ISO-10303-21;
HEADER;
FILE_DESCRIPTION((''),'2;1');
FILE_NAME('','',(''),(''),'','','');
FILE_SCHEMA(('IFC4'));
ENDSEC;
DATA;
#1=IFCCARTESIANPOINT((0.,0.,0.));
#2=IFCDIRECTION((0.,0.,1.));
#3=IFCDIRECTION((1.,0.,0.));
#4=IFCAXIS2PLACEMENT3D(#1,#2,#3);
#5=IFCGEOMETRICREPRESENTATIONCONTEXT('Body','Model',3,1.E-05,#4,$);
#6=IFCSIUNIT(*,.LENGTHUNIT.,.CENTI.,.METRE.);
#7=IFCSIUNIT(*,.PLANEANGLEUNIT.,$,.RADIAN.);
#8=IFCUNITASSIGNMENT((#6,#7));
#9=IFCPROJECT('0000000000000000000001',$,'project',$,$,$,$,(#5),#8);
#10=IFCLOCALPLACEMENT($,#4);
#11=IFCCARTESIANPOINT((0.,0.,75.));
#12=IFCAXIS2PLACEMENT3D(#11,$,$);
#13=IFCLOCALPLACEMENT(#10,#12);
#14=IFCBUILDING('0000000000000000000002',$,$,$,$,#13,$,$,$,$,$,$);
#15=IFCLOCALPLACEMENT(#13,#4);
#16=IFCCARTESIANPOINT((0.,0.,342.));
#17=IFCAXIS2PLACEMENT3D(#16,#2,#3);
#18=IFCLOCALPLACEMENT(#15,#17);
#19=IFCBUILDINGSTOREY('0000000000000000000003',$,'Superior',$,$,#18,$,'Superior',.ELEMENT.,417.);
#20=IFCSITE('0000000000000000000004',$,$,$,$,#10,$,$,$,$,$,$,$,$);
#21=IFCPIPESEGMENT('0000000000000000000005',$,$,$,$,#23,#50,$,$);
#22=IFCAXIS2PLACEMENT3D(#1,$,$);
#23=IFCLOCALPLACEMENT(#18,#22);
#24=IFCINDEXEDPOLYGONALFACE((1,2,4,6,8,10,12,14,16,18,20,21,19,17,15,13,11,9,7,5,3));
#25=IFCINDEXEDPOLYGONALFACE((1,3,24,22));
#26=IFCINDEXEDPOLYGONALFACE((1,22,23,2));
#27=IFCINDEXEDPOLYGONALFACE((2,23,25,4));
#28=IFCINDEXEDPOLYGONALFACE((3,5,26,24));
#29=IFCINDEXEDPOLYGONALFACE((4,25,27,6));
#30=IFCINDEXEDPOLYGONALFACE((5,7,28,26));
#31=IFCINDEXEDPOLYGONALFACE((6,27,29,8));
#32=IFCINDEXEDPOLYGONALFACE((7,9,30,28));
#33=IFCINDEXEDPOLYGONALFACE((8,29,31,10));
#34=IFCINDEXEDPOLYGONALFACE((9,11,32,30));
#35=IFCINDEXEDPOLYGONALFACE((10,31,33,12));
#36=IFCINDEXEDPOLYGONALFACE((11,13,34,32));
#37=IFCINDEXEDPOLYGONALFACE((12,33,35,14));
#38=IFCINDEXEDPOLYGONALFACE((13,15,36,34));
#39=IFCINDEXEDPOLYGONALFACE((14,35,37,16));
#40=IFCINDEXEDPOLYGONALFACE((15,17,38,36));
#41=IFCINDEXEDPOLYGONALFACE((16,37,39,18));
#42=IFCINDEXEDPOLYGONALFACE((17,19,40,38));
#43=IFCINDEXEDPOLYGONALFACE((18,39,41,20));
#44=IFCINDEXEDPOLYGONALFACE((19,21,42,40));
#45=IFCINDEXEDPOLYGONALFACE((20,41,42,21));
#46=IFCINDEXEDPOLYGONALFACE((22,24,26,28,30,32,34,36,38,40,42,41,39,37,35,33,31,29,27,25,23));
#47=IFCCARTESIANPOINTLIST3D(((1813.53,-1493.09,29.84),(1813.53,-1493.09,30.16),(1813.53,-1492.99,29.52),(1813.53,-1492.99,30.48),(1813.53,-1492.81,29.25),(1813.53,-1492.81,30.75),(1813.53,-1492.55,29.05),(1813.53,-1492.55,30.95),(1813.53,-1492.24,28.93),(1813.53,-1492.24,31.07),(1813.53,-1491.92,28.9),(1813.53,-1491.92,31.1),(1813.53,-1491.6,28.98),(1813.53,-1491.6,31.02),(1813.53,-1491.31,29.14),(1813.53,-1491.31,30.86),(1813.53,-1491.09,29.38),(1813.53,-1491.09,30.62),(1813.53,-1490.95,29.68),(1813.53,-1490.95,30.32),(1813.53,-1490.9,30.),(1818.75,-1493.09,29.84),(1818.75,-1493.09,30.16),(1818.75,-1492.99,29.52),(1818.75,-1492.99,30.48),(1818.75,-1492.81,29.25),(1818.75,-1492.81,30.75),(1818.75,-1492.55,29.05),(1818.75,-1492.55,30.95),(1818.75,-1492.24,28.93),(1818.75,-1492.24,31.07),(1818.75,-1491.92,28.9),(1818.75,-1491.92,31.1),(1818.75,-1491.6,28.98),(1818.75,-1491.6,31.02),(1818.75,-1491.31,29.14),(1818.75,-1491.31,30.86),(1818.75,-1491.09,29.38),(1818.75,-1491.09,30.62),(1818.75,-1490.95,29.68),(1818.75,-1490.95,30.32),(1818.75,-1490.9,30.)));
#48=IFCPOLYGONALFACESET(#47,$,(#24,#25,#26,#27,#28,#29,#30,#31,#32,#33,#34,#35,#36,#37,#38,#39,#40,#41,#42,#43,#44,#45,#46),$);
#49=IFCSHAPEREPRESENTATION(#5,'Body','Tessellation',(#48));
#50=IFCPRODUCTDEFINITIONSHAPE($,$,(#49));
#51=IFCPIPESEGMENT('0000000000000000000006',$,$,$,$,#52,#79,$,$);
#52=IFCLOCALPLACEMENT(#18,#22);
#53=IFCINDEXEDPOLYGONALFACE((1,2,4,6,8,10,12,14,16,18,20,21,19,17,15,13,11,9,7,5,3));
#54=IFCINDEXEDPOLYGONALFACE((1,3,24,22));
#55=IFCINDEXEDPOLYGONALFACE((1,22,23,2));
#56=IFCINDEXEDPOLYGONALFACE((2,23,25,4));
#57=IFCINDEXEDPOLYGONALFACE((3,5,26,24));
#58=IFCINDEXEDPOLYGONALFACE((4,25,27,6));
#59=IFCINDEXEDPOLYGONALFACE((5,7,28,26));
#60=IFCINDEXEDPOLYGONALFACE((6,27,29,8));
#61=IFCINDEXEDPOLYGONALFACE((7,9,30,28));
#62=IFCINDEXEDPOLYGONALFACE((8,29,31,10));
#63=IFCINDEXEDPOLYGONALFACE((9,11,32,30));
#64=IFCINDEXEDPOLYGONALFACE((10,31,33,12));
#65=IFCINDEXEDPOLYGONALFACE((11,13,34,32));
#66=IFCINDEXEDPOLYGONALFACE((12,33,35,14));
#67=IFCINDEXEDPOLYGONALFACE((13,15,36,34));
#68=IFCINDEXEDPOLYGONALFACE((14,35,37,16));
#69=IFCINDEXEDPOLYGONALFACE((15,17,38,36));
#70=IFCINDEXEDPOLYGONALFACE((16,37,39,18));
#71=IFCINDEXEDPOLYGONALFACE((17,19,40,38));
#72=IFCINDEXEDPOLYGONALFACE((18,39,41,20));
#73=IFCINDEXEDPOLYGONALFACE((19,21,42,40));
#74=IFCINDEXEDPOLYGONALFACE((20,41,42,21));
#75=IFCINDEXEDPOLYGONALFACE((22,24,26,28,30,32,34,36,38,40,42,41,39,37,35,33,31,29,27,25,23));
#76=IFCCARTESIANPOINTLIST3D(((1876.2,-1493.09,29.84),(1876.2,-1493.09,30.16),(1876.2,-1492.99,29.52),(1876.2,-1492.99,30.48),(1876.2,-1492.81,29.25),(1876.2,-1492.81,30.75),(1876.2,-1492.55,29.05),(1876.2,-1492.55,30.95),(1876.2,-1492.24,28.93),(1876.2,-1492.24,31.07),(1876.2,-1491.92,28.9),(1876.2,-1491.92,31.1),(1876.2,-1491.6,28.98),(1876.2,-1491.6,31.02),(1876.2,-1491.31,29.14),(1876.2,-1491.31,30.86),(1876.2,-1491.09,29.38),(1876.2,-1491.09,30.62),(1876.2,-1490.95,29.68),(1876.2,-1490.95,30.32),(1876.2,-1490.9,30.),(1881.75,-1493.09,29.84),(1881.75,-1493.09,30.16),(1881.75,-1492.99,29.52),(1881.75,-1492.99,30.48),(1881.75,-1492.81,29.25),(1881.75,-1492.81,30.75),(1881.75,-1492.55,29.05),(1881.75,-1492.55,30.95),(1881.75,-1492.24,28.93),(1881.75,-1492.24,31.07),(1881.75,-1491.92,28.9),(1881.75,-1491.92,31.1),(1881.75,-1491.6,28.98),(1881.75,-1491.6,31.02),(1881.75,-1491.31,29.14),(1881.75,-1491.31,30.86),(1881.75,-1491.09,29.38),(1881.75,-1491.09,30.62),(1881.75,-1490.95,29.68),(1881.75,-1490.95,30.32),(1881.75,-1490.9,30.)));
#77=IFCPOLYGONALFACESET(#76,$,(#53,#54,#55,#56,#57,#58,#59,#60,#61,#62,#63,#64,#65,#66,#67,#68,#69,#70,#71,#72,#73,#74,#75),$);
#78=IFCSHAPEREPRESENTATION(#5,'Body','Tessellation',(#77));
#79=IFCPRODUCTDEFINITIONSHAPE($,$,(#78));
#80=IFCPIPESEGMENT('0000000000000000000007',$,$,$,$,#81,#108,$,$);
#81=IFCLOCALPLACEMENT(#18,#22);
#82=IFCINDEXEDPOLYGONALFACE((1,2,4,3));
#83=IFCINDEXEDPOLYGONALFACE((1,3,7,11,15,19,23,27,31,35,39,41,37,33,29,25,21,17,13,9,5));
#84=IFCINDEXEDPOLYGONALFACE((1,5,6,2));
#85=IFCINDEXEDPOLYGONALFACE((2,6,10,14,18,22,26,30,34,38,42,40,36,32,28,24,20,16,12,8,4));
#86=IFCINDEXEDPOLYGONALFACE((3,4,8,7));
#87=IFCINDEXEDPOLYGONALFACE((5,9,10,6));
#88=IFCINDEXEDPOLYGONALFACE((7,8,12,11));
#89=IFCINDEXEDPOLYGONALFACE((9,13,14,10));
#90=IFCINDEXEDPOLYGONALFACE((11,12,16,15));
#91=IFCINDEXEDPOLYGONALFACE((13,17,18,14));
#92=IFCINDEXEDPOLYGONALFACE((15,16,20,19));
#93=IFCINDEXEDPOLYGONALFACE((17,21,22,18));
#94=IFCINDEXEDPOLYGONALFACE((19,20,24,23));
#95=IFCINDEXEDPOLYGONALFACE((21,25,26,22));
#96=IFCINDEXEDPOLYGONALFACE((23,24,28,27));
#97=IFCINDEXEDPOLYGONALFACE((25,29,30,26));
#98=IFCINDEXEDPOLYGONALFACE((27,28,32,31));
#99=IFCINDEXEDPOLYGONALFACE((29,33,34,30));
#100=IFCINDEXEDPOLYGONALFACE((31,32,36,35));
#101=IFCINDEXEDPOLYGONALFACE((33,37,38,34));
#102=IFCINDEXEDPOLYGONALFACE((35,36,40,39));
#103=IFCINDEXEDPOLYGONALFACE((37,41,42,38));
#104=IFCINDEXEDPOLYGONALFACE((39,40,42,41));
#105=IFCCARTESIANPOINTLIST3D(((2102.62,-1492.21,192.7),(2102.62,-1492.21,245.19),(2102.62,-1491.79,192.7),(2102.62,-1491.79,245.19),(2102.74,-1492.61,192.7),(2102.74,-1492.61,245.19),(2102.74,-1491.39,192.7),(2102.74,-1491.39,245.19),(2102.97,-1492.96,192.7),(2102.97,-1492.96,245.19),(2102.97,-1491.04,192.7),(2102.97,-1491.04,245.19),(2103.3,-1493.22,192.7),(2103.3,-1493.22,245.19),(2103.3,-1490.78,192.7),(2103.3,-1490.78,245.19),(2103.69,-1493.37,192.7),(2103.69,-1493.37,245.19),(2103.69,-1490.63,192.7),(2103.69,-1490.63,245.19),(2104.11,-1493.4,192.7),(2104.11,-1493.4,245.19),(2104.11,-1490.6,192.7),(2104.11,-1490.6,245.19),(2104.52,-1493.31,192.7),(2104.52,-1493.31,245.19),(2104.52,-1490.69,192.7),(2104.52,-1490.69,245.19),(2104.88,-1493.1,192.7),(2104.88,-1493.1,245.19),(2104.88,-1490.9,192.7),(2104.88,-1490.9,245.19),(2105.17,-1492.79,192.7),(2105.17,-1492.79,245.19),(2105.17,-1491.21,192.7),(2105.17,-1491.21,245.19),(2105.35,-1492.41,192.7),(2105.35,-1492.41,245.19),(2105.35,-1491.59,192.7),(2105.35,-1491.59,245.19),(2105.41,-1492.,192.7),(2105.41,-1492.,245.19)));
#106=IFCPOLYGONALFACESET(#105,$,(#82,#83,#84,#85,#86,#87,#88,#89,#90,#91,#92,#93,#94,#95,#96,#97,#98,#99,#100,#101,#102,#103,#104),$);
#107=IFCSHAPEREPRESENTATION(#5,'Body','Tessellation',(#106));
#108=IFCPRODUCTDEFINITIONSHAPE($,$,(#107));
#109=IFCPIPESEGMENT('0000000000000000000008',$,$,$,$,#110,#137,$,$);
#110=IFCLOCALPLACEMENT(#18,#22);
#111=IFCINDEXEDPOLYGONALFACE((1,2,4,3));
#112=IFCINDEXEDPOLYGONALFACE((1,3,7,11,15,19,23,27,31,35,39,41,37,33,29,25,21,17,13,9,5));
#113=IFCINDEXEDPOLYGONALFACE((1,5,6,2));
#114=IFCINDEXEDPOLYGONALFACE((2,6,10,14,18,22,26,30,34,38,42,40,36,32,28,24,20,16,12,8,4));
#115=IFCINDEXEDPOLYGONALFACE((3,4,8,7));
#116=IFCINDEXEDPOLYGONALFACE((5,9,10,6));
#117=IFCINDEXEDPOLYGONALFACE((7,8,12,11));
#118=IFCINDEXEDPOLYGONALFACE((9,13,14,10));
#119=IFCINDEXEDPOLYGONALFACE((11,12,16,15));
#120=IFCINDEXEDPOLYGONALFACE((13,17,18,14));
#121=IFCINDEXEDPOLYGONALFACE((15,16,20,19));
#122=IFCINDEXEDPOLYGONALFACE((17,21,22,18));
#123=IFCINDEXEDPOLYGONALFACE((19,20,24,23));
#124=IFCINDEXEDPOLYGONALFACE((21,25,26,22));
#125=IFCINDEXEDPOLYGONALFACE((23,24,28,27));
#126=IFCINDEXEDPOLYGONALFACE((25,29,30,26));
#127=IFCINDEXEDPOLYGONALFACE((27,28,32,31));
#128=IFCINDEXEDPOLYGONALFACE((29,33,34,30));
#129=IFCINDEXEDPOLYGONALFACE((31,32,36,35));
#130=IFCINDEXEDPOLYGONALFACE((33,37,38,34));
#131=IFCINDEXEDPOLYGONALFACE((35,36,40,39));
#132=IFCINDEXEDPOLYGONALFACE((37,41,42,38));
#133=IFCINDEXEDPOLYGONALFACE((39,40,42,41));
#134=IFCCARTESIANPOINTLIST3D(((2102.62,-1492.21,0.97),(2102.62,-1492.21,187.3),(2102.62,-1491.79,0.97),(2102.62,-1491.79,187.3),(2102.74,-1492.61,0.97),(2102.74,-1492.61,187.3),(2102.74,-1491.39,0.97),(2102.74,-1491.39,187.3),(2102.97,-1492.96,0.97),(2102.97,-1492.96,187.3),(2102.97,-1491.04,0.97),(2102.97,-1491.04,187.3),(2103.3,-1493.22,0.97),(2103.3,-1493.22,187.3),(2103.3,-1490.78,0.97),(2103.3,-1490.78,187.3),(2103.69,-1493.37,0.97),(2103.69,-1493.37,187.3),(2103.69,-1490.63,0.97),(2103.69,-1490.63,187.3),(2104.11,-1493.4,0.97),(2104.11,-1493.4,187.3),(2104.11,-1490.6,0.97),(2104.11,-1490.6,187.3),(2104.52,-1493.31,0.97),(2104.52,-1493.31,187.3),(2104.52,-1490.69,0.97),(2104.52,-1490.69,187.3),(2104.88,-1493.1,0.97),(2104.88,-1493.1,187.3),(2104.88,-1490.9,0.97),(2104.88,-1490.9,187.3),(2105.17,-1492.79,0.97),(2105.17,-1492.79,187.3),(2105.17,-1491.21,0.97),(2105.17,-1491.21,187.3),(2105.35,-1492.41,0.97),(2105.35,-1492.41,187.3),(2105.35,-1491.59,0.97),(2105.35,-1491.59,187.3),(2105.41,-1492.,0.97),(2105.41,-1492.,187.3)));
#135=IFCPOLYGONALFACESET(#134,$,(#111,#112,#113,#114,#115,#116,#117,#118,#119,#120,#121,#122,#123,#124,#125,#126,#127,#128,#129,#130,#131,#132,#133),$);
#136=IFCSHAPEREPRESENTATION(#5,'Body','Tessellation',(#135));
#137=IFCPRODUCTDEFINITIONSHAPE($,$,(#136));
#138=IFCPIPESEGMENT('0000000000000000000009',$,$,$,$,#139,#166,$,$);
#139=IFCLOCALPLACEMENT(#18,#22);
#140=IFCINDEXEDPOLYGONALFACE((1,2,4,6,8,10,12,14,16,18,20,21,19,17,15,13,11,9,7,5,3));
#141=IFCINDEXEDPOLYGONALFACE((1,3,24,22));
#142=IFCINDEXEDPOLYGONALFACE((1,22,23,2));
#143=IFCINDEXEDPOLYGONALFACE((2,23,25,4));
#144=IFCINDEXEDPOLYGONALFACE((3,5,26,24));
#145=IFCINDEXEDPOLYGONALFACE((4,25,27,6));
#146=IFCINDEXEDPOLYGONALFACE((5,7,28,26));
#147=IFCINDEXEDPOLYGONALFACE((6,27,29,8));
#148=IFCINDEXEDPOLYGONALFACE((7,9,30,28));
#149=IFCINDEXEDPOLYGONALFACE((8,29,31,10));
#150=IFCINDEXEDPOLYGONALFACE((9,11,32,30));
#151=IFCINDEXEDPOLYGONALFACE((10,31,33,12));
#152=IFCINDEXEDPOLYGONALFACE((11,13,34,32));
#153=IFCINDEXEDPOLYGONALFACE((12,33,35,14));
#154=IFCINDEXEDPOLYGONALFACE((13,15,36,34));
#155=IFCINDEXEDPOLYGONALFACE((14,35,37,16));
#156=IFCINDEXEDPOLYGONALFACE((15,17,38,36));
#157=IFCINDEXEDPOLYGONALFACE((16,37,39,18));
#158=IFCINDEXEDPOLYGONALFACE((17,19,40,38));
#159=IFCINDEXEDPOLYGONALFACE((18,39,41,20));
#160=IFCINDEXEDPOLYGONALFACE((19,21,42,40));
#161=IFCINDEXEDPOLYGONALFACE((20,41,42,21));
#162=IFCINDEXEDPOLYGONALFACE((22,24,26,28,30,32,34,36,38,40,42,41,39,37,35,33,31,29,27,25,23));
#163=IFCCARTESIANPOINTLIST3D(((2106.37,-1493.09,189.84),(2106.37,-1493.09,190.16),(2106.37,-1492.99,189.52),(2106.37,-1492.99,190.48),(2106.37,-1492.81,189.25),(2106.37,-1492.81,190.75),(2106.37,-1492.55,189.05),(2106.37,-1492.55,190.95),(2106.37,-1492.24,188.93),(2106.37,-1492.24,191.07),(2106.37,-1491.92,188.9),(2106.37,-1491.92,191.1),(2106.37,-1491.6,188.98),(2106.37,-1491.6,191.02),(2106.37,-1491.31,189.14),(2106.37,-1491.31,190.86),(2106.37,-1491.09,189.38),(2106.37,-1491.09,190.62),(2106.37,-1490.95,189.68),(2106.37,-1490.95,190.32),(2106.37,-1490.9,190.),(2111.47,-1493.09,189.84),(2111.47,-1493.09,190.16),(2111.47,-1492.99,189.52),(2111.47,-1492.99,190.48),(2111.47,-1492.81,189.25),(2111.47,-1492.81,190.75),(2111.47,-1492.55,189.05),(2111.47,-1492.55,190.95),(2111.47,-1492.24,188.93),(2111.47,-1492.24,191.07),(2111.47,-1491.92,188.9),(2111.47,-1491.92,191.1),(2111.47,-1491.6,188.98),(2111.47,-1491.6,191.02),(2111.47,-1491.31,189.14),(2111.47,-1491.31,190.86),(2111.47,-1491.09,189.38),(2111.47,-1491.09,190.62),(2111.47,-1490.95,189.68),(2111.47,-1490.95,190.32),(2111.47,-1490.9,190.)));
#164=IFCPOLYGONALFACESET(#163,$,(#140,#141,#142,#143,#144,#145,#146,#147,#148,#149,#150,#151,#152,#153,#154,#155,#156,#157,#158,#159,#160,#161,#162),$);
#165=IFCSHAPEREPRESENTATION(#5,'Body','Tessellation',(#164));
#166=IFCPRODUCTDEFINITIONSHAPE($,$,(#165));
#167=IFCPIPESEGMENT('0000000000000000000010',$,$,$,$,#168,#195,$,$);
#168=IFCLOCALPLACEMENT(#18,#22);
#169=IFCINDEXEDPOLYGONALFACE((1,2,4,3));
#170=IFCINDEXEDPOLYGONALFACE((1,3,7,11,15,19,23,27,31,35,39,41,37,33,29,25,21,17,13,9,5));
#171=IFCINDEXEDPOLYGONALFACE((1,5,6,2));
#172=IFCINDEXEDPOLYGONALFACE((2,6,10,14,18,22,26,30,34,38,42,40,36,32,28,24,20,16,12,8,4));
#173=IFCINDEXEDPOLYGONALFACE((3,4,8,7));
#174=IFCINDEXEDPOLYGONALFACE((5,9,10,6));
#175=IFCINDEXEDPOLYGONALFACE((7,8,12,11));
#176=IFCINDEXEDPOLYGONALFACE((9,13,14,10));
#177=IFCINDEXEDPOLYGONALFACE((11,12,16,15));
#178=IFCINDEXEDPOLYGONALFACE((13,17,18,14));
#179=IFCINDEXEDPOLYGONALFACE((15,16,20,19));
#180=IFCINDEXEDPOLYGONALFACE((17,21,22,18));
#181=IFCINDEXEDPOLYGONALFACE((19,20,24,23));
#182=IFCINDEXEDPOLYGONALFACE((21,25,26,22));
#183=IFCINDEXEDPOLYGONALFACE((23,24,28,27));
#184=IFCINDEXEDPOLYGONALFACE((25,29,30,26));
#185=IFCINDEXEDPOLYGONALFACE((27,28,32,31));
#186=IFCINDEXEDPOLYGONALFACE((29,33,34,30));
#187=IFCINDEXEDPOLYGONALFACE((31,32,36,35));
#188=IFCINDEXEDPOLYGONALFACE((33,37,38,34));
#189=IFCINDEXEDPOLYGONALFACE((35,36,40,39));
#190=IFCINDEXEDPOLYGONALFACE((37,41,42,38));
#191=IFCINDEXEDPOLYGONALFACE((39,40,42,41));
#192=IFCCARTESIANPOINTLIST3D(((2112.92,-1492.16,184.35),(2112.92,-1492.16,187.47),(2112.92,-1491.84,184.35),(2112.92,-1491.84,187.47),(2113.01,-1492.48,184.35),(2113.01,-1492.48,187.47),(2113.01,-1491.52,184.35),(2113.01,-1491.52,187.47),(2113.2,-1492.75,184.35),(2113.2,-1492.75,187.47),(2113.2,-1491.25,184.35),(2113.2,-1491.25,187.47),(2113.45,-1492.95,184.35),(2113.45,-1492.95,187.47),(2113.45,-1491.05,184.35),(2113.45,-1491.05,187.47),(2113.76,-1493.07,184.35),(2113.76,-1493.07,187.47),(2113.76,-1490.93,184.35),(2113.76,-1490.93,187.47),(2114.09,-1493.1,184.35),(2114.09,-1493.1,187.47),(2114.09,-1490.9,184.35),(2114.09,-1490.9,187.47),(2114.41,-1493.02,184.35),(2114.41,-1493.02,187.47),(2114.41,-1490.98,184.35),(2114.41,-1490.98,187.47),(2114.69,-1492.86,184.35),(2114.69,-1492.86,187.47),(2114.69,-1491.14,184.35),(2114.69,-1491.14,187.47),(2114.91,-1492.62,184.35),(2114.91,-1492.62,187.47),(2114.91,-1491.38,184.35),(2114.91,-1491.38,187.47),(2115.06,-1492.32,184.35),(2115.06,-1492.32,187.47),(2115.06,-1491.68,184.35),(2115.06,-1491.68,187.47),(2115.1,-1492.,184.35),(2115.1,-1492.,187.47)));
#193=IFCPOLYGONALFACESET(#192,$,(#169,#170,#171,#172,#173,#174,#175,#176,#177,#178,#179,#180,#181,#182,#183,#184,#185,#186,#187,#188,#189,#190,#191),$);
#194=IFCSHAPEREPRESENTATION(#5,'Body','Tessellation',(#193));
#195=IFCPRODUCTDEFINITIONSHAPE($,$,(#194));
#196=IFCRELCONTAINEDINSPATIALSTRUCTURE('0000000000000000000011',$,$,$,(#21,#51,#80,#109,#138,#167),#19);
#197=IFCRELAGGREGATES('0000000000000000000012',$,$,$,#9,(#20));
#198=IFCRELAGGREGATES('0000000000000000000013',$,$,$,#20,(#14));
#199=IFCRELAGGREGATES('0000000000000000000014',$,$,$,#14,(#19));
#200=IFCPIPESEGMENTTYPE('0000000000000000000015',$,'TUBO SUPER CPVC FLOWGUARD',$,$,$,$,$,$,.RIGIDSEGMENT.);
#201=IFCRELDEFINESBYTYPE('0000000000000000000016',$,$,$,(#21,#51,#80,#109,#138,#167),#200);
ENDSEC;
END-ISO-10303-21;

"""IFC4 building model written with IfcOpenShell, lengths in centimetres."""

from ifc_helpers import new_model, si_unit, frame, origin_with_axes, origin_2d_with_axis, place, context, project, spatial, circle, extrude, type_object, element, save


model = new_model("IFC4")

# Units and contexts
model_context = context("Model", 3, precision=1e-05, world=origin_with_axes(), identifier="Body")
ifc_project = project(units=[si_unit("LENGTHUNIT", "METRE", prefix="CENTI"), si_unit("PLANEANGLEUNIT", "RADIAN")], contexts=[model_context])

# Site, building, storey
site_placement = place(None, origin_with_axes())
site = spatial("IfcSite", under=ifc_project, at=site_placement)
building_placement = place(site_placement, frame((0.0, 0.0, 75.0)))
building = spatial("IfcBuilding", under=site, at=building_placement)
placement = place(building_placement, origin_with_axes())
storey_placement = place(placement, frame((0.0, 0.0, 342.0), z_axis=(0.0, 0.0, 1.0), x_axis=(1.0, 0.0, 0.0)))
storey = spatial("IfcBuildingStorey", under=building, at=storey_placement, Name="Superior", LongName="Superior", CompositionType="ELEMENT", Elevation=417.0)

# Pipe segments
pipe_segment_type_1 = type_object("IfcPipeSegmentType", Name="TUBO SUPER CPVC FLOWGUARD", PredefinedType="RIGIDSEGMENT")
pipe_segment_1_placement = place(storey_placement, frame((1816.14, -1492.0, 31.1), z_axis=(0.0, 0.0, 1.0), x_axis=(1.0, 0.0, 0.0)))
element("IfcPipeSegment", 1, at=pipe_segment_1_placement, inside=storey, type_object=pipe_segment_type_1, context=model_context, shape_type="SolidModel", body=[
    extrude(circle(Radius=1.1, at=origin_2d_with_axis()), frame((2.61, 0.0, -1.1), z_axis=(-1.0, 0.0, 0.0), x_axis=(0.0, 1.0, 0.0)), (0.0, 0.0, 1.0), 5.22),
])
pipe_segment_2_placement = place(storey_placement, frame((1878.98, -1492.0, 31.1), z_axis=(0.0, 0.0, 1.0), x_axis=(1.0, 0.0, 0.0)))
element("IfcPipeSegment", 2, at=pipe_segment_2_placement, inside=storey, type_object=pipe_segment_type_1, context=model_context, shape_type="SolidModel", body=[
    extrude(circle(Radius=1.1, at=origin_2d_with_axis()), frame((2.77, 0.0, -1.1), z_axis=(-1.0, 0.0, 0.0), x_axis=(0.0, 1.0, 0.0)), (0.0, 0.0, 1.0), 5.55),
])
pipe_segment_3_placement = place(storey_placement, frame((2104.0, -1492.0, 245.19), z_axis=(0.0, 0.0, 1.0), x_axis=(1.0, 0.0, 0.0)))
element("IfcPipeSegment", 3, at=pipe_segment_3_placement, inside=storey, type_object=pipe_segment_type_1, context=model_context, shape_type="SolidModel", body=[
    extrude(circle(Radius=1.41, at=origin_2d_with_axis()), frame((0.0, 0.0, 0.0), z_axis=(0.0, 0.0, -1.0), x_axis=(1.0, 0.0, 0.0)), (0.0, 0.0, 1.0), 52.49),
])
pipe_segment_4_placement = place(storey_placement, frame((2104.0, -1492.0, 187.3), z_axis=(0.0, 0.0, 1.0), x_axis=(1.0, 0.0, 0.0)))
element("IfcPipeSegment", 4, at=pipe_segment_4_placement, inside=storey, type_object=pipe_segment_type_1, context=model_context, shape_type="SolidModel", body=[
    extrude(circle(Radius=1.41, at=origin_2d_with_axis()), frame((0.0, 0.0, 0.0), z_axis=(0.0, 0.0, -1.0), x_axis=(1.0, 0.0, 0.0)), (0.0, 0.0, 1.0), 186.33),
])
pipe_segment_5_placement = place(storey_placement, frame((2108.92, -1492.0, 191.1), z_axis=(0.0, 0.0, 1.0), x_axis=(1.0, 0.0, 0.0)))
element("IfcPipeSegment", 5, at=pipe_segment_5_placement, inside=storey, type_object=pipe_segment_type_1, context=model_context, shape_type="SolidModel", body=[
    extrude(circle(Radius=1.1, at=origin_2d_with_axis()), frame((-2.55, 0.0, -1.1), z_axis=(1.0, 0.0, 0.0), x_axis=(0.0, 1.0, 0.0)), (0.0, 0.0, 1.0), 5.1),
])
pipe_segment_6_placement = place(storey_placement, frame((2114.0, -1492.0, 187.47), z_axis=(0.0, 0.0, 1.0), x_axis=(1.0, 0.0, 0.0)))
element("IfcPipeSegment", 6, at=pipe_segment_6_placement, inside=storey, type_object=pipe_segment_type_1, context=model_context, shape_type="SolidModel", body=[
    extrude(circle(Radius=1.1, at=origin_2d_with_axis()), frame((0.0, 0.0, 0.0), z_axis=(0.0, 0.0, -1.0), x_axis=(1.0, 0.0, 0.0)), (0.0, 0.0, 1.0), 3.12),
])

save(model, "model.ifc")
